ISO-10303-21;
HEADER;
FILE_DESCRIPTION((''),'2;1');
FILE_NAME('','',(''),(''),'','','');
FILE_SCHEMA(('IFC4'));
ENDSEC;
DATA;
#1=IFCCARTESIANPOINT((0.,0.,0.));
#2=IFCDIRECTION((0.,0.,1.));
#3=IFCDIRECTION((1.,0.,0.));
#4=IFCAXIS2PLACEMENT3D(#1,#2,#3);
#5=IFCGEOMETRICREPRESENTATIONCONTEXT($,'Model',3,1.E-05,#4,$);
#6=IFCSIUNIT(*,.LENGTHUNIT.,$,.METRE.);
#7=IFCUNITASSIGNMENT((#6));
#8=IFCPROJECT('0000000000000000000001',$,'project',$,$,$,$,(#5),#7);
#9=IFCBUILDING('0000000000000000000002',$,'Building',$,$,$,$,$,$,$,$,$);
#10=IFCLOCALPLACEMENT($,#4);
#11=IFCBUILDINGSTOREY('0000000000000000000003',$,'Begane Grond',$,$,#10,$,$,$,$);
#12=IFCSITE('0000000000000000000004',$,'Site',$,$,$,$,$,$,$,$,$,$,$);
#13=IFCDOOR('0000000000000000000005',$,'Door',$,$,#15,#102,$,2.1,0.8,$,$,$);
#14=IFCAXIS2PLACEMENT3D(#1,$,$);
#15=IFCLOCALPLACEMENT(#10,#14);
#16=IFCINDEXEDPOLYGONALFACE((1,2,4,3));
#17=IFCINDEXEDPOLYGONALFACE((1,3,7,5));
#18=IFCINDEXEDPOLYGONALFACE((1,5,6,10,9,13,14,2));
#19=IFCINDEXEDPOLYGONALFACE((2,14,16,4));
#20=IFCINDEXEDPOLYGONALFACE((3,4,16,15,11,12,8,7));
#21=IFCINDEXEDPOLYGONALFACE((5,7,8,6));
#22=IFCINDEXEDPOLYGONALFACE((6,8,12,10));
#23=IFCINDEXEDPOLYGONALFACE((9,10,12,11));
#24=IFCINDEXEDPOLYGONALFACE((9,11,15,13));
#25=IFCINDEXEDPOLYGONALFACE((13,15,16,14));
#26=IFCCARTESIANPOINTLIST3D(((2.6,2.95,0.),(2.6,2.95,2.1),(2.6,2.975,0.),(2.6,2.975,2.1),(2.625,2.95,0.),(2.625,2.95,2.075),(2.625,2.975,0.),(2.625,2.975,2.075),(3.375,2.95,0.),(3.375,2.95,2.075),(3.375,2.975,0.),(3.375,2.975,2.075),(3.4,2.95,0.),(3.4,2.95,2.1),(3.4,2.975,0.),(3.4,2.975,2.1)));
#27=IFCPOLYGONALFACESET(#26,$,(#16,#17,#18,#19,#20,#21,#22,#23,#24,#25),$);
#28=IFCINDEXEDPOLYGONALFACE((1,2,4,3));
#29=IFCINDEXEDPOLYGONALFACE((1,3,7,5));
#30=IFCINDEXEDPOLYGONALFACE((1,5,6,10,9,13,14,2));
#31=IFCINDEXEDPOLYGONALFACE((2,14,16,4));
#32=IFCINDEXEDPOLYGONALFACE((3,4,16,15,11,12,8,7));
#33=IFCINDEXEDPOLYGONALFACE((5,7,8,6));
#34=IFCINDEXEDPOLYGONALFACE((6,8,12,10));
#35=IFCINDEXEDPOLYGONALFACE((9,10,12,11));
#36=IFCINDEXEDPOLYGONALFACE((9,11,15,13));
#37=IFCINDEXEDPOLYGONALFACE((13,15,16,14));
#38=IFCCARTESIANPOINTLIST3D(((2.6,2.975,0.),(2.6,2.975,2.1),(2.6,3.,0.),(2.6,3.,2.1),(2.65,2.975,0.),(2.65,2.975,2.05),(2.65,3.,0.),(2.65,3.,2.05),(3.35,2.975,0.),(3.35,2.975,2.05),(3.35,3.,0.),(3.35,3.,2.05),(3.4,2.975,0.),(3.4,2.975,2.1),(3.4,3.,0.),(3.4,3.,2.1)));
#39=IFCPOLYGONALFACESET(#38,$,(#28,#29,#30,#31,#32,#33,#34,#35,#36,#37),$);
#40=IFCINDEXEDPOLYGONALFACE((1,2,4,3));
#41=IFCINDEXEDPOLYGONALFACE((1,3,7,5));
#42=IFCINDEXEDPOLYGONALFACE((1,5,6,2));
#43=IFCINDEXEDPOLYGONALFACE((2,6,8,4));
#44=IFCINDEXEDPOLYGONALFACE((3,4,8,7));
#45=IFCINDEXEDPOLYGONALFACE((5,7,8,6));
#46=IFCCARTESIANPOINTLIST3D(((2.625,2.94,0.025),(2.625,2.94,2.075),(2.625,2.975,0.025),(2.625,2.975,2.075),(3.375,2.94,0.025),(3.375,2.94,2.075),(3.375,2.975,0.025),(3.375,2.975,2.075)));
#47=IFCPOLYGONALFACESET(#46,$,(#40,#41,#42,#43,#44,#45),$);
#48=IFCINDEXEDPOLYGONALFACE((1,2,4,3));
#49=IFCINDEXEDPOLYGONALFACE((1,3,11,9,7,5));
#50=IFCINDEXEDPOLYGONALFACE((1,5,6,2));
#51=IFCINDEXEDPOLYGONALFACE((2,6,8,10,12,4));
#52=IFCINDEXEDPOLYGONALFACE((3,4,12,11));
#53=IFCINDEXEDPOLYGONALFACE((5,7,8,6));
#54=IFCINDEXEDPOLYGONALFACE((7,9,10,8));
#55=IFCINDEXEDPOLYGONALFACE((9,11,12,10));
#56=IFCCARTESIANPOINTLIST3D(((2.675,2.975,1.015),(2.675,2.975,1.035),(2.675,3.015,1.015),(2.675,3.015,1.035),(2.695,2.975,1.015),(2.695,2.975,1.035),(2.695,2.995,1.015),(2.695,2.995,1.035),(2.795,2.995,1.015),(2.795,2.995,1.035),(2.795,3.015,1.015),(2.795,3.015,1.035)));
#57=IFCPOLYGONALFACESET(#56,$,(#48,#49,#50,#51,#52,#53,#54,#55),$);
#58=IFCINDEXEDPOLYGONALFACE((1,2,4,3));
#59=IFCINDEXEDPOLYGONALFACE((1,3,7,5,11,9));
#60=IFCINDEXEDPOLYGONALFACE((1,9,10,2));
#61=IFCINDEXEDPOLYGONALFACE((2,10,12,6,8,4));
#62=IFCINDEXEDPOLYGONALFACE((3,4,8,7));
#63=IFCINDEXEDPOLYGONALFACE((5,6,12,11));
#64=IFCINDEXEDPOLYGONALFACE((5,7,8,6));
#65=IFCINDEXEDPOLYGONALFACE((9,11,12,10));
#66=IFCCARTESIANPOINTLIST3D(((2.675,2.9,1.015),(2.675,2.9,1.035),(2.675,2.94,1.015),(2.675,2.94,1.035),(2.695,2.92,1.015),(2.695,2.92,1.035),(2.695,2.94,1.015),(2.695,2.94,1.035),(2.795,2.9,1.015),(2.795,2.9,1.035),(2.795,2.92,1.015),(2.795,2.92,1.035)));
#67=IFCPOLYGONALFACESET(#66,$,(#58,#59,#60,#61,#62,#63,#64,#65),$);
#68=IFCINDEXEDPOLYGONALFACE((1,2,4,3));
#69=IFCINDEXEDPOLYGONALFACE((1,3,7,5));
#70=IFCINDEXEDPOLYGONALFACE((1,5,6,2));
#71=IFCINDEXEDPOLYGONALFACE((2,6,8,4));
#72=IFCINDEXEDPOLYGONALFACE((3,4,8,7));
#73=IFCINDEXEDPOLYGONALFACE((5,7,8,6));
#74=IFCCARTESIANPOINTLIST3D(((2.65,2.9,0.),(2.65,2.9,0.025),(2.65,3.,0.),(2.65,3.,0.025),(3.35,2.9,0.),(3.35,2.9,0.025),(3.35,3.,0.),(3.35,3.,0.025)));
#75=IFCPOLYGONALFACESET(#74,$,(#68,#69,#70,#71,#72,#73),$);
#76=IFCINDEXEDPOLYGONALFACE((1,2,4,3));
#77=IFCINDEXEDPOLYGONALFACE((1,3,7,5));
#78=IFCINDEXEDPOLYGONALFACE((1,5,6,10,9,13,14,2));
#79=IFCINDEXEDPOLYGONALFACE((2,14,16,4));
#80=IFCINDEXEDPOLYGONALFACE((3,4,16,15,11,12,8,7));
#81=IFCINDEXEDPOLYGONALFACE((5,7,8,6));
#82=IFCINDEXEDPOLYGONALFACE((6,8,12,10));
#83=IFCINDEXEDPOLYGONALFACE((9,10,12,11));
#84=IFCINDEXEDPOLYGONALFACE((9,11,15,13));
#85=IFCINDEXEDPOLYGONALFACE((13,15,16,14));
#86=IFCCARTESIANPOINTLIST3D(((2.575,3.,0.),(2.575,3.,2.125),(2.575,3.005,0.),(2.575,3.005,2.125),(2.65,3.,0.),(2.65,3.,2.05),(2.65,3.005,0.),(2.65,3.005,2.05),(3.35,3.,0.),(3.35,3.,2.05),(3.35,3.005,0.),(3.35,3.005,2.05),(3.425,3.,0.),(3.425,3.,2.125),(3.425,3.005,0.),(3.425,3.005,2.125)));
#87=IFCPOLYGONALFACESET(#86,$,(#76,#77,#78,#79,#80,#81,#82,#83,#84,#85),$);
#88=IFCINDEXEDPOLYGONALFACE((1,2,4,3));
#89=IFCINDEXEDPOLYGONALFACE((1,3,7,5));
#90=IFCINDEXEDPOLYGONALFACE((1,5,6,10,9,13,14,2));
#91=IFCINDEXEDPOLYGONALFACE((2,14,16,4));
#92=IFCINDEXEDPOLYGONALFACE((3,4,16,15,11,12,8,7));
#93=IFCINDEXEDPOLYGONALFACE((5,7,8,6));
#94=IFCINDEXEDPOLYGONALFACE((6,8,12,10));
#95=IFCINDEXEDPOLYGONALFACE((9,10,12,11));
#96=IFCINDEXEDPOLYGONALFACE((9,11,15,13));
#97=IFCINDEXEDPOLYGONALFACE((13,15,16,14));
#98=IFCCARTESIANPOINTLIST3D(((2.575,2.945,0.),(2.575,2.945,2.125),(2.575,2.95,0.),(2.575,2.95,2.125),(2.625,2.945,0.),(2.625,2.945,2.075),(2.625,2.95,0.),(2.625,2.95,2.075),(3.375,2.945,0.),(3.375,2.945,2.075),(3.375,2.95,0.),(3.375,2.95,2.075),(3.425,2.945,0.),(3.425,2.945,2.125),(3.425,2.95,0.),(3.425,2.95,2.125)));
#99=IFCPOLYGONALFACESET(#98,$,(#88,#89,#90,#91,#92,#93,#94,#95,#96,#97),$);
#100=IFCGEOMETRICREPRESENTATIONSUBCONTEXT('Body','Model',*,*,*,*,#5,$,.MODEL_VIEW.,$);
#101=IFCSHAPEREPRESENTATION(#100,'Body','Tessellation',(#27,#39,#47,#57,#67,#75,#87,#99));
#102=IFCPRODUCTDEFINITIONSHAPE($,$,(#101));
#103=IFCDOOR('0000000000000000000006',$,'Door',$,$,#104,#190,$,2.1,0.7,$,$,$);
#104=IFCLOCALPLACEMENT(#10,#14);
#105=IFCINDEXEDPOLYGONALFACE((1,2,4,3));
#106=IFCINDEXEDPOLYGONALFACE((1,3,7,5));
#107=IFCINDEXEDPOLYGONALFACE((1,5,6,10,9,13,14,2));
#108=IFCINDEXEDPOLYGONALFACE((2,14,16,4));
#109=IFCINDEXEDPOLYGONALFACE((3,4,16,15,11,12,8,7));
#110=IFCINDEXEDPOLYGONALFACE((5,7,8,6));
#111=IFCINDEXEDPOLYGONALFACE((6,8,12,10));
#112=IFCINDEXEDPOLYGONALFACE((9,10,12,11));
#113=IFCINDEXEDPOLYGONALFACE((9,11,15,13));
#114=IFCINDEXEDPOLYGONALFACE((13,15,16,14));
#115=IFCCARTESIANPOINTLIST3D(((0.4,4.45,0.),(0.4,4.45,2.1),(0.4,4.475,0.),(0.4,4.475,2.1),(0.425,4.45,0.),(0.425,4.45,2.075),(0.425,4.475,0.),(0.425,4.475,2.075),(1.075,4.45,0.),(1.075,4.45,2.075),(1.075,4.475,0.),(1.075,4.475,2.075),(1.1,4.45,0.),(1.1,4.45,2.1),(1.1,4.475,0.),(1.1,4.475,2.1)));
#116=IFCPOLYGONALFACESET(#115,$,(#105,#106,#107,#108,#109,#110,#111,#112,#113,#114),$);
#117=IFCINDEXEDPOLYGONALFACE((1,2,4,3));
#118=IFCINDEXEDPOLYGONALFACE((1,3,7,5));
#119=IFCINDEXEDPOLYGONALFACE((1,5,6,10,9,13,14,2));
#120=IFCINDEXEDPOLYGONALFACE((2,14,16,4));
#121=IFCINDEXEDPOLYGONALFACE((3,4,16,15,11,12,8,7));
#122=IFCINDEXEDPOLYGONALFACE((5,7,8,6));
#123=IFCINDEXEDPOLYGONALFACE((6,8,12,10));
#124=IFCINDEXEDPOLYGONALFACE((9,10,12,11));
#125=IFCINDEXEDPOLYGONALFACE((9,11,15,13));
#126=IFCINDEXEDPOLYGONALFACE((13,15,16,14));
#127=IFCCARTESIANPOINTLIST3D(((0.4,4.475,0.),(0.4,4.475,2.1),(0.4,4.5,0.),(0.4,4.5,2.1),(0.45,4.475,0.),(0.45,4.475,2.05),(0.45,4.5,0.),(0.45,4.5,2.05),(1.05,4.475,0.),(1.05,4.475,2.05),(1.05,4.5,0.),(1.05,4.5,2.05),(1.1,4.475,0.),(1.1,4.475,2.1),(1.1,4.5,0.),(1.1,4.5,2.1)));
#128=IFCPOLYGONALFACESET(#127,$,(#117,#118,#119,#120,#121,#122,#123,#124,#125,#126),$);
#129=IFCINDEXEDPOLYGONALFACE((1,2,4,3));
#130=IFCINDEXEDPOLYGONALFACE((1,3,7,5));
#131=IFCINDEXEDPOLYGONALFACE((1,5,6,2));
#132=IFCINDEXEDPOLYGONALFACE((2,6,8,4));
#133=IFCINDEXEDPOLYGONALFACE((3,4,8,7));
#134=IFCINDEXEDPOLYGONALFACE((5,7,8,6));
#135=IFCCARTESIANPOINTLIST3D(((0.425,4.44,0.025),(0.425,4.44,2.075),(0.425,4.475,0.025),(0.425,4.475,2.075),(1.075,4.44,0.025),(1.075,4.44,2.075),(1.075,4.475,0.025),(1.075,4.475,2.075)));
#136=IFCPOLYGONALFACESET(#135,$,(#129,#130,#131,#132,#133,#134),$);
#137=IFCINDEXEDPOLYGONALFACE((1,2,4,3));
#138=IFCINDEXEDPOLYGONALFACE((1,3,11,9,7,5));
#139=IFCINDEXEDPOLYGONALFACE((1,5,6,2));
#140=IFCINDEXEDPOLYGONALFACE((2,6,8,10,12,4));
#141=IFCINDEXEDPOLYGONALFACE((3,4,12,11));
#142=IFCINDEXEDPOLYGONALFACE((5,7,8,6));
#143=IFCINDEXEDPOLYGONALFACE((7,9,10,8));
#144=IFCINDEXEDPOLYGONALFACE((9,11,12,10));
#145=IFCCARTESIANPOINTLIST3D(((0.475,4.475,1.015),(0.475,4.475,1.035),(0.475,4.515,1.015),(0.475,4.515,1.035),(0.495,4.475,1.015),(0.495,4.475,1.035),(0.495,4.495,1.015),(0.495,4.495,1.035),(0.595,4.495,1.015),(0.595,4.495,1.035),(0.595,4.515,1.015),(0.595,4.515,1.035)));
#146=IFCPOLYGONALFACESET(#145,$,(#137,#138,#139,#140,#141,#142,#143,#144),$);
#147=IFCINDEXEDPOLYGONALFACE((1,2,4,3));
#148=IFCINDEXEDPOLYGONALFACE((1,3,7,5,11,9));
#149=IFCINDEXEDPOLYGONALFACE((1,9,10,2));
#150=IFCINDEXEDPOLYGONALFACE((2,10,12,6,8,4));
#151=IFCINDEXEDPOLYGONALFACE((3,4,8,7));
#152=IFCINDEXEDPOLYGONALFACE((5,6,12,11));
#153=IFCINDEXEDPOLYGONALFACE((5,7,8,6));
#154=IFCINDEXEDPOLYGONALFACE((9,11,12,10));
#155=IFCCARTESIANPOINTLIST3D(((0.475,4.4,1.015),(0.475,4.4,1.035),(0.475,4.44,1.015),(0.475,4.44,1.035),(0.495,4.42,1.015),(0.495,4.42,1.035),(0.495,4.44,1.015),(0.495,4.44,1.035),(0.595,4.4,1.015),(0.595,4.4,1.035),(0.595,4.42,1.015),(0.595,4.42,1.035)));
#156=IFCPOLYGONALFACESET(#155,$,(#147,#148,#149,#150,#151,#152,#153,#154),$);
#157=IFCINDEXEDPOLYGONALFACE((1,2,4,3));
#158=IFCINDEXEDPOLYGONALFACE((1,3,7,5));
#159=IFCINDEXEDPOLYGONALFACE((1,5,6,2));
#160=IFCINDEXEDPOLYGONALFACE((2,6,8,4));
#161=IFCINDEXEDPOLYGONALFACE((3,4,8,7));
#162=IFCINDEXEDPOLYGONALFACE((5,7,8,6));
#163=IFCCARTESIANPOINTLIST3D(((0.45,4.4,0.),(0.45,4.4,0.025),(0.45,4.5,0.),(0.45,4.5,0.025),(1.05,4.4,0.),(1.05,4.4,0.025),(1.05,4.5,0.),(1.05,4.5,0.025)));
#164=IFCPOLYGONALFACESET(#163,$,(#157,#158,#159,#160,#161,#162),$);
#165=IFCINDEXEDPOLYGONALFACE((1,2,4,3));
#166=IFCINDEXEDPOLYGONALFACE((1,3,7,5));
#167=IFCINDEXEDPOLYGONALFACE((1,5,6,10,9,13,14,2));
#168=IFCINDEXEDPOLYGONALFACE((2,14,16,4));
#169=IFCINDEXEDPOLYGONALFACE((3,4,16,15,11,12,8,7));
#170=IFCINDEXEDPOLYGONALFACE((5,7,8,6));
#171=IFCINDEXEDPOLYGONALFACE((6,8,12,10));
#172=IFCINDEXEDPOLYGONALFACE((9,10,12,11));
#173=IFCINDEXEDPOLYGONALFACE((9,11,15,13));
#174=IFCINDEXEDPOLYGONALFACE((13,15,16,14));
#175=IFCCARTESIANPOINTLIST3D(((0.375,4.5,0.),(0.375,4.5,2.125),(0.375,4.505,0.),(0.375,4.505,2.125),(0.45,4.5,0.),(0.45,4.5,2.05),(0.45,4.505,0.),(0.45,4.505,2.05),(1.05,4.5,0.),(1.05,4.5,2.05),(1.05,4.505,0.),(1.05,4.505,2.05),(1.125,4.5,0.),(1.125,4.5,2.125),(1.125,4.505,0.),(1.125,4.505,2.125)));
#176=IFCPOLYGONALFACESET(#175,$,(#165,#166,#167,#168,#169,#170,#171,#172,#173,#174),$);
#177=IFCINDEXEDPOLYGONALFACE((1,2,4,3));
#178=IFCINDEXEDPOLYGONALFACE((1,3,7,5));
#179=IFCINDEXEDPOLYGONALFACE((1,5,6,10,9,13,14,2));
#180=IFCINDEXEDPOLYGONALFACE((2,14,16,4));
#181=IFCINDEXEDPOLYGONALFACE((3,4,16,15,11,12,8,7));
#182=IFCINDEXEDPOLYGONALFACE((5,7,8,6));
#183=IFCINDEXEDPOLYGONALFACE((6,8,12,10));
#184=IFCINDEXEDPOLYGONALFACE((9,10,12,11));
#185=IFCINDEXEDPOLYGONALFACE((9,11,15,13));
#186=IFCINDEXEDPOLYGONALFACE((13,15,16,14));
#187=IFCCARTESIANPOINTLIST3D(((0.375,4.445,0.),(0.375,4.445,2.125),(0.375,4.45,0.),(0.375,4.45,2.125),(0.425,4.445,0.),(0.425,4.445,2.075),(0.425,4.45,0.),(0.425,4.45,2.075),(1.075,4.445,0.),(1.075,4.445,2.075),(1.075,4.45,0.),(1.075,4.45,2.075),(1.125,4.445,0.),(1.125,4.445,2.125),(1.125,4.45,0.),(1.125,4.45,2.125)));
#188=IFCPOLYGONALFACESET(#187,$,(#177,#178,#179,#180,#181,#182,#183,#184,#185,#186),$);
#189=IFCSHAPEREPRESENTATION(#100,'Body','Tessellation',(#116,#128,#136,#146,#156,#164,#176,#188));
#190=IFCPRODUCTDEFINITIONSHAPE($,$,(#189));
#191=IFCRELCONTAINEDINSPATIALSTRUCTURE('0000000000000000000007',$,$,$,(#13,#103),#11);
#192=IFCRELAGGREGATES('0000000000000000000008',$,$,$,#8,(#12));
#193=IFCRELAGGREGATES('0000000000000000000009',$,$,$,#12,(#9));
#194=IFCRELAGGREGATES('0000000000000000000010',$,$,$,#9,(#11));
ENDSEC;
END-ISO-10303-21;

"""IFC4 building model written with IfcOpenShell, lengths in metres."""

from ifc_helpers import new_model, si_unit, frame, origin_with_axes, place, context, subcontext, project, spatial, line, indexed_curve, outline, extrude, element, save


model = new_model("IFC4")

# Units and contexts
model_context = context("Model", 3, precision=1e-05, world=origin_with_axes())
body_context = subcontext(model_context, "Body", "Model", "MODEL_VIEW")
ifc_project = project(units=[si_unit("LENGTHUNIT", "METRE")], contexts=[model_context])

# Site, building, storey
site = spatial("IfcSite", under=ifc_project, Name="Site")
building = spatial("IfcBuilding", under=site, Name="Building")
storey_placement = place(None, origin_with_axes())
storey = spatial("IfcBuildingStorey", under=building, at=storey_placement, Name="Begane Grond")

# Doors
door_1_placement = place(storey_placement, frame((3.4, 3.0, 0.0), z_axis=(0.0, 0.0, 1.0), x_axis=(-1.0, 0.0, 0.0)))
element("IfcDoor", 1, at=door_1_placement, inside=storey, Name="Door", OverallHeight=2.1, OverallWidth=0.8, context=body_context, shape_type="SweptSolid", body=[
    extrude(outline(indexed_curve([(0.0, 0.0), (0.0, 2.1), (0.8, 2.1), (0.8, 0.0), (0.775, 0.0), (0.775, 2.075), (0.025, 2.075), (0.025, 0.0)], segments=[line(1, 2, 3, 4, 5, 6, 7, 8, 1)])), frame((0.0, 0.025, 0.0), z_axis=(0.0, -1.0, 0.0), x_axis=(1.0, 0.0, 0.0)), (0.0, 0.0, -1.0), 0.025),
    extrude(outline(indexed_curve([(0.0, 0.0), (0.0, 2.1), (0.8, 2.1), (0.8, 0.0), (0.75, 0.0), (0.75, 2.05), (0.05, 2.05), (0.05, 0.0)], segments=[line(1, 2, 3, 4, 5, 6, 7, 8, 1)])), frame((0.0, 0.0, 0.0), z_axis=(0.0, -1.0, 0.0), x_axis=(1.0, 0.0, 0.0)), (0.0, 0.0, -1.0), 0.025),
    extrude(outline(indexed_curve([(0.0, 0.0), (0.75, 0.0), (0.75, 0.035), (0.0, 0.035)], segments=[line(1, 2, 3, 4, 1)])), frame((0.025, 0.025, 0.025), z_axis=(0.0, 0.0, 1.0), x_axis=(1.0, 0.0, 0.0)), (0.0, 0.0, 1.0), 2.05),
    extrude(outline(indexed_curve([(0.0, 0.0), (0.0, -0.04), (-0.12, -0.04), (-0.12, -0.02), (-0.02, -0.02), (-0.02, 0.0)], segments=[line(1, 2, 3, 4, 5, 6, 1)])), frame((0.725, 0.025, 1.015), z_axis=(0.0, 0.0, 1.0), x_axis=(1.0, 0.0, 0.0)), (0.0, 0.0, 1.0), 0.02),
    extrude(outline(indexed_curve([(0.0, 0.0), (0.0, 0.04), (-0.12, 0.04), (-0.12, 0.02), (-0.02, 0.02), (-0.02, 0.0)], segments=[line(1, 2, 3, 4, 5, 6, 1)])), frame((0.725, 0.06, 1.015), z_axis=(0.0, 0.0, 1.0), x_axis=(1.0, 0.0, 0.0)), (0.0, 0.0, 1.0), 0.02),
    extrude(outline(indexed_curve([(0.0, 0.0), (0.7, 0.0), (0.7, 0.1), (0.0, 0.1)], segments=[line(1, 2, 3, 4, 1)])), frame((0.05, 0.0, 0.0), z_axis=(0.0, 0.0, 1.0), x_axis=(1.0, 0.0, 0.0)), (0.0, 0.0, 1.0), 0.025),
    extrude(outline(indexed_curve([(0.0, 0.0), (0.0, 2.125), (0.85, 2.125), (0.85, 0.0), (0.775, 0.0), (0.775, 2.05), (0.075, 2.05), (0.075, 0.0)], segments=[line(1, 2, 3, 4, 5, 6, 7, 8, 1)])), frame((-0.025, -0.005, 0.0), z_axis=(0.0, -1.0, 0.0), x_axis=(1.0, 0.0, 0.0)), (0.0, 0.0, -1.0), 0.005),
    extrude(outline(indexed_curve([(0.0, 0.0), (0.0, 2.125), (0.85, 2.125), (0.85, 0.0), (0.8, 0.0), (0.8, 2.075), (0.05, 2.075), (0.05, 0.0)], segments=[line(1, 2, 3, 4, 5, 6, 7, 8, 1)])), frame((-0.025, 0.05, 0.0), z_axis=(0.0, -1.0, 0.0), x_axis=(1.0, 0.0, 0.0)), (0.0, 0.0, -1.0), 0.005),
])
door_2_placement = place(storey_placement, frame((1.1, 4.5, 0.0), z_axis=(0.0, 0.0, 1.0), x_axis=(-1.0, 0.0, 0.0)))
element("IfcDoor", 2, at=door_2_placement, inside=storey, Name="Door", OverallHeight=2.1, OverallWidth=0.7, context=body_context, shape_type="SweptSolid", body=[
    extrude(outline(indexed_curve([(0.0, 0.0), (0.0, 2.1), (0.7, 2.1), (0.7, 0.0), (0.675, 0.0), (0.675, 2.075), (0.025, 2.075), (0.025, 0.0)], segments=[line(1, 2, 3, 4, 5, 6, 7, 8, 1)])), frame((0.0, 0.025, 0.0), z_axis=(0.0, -1.0, 0.0), x_axis=(1.0, 0.0, 0.0)), (0.0, 0.0, -1.0), 0.025),
    extrude(outline(indexed_curve([(0.0, 0.0), (0.0, 2.1), (0.7, 2.1), (0.7, 0.0), (0.65, 0.0), (0.65, 2.05), (0.05, 2.05), (0.05, 0.0)], segments=[line(1, 2, 3, 4, 5, 6, 7, 8, 1)])), frame((0.0, 0.0, 0.0), z_axis=(0.0, -1.0, 0.0), x_axis=(1.0, 0.0, 0.0)), (0.0, 0.0, -1.0), 0.025),
    extrude(outline(indexed_curve([(0.0, 0.0), (0.65, 0.0), (0.65, 0.035), (0.0, 0.035)], segments=[line(1, 2, 3, 4, 1)])), frame((0.025, 0.025, 0.025), z_axis=(0.0, 0.0, 1.0), x_axis=(1.0, 0.0, 0.0)), (0.0, 0.0, 1.0), 2.05),
    extrude(outline(indexed_curve([(0.0, 0.0), (0.0, -0.04), (-0.12, -0.04), (-0.12, -0.02), (-0.02, -0.02), (-0.02, 0.0)], segments=[line(1, 2, 3, 4, 5, 6, 1)])), frame((0.625, 0.025, 1.015), z_axis=(0.0, 0.0, 1.0), x_axis=(1.0, 0.0, 0.0)), (0.0, 0.0, 1.0), 0.02),
    extrude(outline(indexed_curve([(0.0, 0.0), (0.0, 0.04), (-0.12, 0.04), (-0.12, 0.02), (-0.02, 0.02), (-0.02, 0.0)], segments=[line(1, 2, 3, 4, 5, 6, 1)])), frame((0.625, 0.06, 1.015), z_axis=(0.0, 0.0, 1.0), x_axis=(1.0, 0.0, 0.0)), (0.0, 0.0, 1.0), 0.02),
    extrude(outline(indexed_curve([(0.0, 0.0), (0.6, 0.0), (0.6, 0.1), (0.0, 0.1)], segments=[line(1, 2, 3, 4, 1)])), frame((0.05, 0.0, 0.0), z_axis=(0.0, 0.0, 1.0), x_axis=(1.0, 0.0, 0.0)), (0.0, 0.0, 1.0), 0.025),
    extrude(outline(indexed_curve([(0.0, 0.0), (0.0, 2.125), (0.75, 2.125), (0.75, 0.0), (0.675, 0.0), (0.675, 2.05), (0.075, 2.05), (0.075, 0.0)], segments=[line(1, 2, 3, 4, 5, 6, 7, 8, 1)])), frame((-0.025, -0.005, 0.0), z_axis=(0.0, -1.0, 0.0), x_axis=(1.0, 0.0, 0.0)), (0.0, 0.0, -1.0), 0.005),
    extrude(outline(indexed_curve([(0.0, 0.0), (0.0, 2.125), (0.75, 2.125), (0.75, 0.0), (0.7, 0.0), (0.7, 2.075), (0.05, 2.075), (0.05, 0.0)], segments=[line(1, 2, 3, 4, 5, 6, 7, 8, 1)])), frame((-0.025, 0.05, 0.0), z_axis=(0.0, -1.0, 0.0), x_axis=(1.0, 0.0, 0.0)), (0.0, 0.0, -1.0), 0.005),
])

save(model, "model.ifc")
